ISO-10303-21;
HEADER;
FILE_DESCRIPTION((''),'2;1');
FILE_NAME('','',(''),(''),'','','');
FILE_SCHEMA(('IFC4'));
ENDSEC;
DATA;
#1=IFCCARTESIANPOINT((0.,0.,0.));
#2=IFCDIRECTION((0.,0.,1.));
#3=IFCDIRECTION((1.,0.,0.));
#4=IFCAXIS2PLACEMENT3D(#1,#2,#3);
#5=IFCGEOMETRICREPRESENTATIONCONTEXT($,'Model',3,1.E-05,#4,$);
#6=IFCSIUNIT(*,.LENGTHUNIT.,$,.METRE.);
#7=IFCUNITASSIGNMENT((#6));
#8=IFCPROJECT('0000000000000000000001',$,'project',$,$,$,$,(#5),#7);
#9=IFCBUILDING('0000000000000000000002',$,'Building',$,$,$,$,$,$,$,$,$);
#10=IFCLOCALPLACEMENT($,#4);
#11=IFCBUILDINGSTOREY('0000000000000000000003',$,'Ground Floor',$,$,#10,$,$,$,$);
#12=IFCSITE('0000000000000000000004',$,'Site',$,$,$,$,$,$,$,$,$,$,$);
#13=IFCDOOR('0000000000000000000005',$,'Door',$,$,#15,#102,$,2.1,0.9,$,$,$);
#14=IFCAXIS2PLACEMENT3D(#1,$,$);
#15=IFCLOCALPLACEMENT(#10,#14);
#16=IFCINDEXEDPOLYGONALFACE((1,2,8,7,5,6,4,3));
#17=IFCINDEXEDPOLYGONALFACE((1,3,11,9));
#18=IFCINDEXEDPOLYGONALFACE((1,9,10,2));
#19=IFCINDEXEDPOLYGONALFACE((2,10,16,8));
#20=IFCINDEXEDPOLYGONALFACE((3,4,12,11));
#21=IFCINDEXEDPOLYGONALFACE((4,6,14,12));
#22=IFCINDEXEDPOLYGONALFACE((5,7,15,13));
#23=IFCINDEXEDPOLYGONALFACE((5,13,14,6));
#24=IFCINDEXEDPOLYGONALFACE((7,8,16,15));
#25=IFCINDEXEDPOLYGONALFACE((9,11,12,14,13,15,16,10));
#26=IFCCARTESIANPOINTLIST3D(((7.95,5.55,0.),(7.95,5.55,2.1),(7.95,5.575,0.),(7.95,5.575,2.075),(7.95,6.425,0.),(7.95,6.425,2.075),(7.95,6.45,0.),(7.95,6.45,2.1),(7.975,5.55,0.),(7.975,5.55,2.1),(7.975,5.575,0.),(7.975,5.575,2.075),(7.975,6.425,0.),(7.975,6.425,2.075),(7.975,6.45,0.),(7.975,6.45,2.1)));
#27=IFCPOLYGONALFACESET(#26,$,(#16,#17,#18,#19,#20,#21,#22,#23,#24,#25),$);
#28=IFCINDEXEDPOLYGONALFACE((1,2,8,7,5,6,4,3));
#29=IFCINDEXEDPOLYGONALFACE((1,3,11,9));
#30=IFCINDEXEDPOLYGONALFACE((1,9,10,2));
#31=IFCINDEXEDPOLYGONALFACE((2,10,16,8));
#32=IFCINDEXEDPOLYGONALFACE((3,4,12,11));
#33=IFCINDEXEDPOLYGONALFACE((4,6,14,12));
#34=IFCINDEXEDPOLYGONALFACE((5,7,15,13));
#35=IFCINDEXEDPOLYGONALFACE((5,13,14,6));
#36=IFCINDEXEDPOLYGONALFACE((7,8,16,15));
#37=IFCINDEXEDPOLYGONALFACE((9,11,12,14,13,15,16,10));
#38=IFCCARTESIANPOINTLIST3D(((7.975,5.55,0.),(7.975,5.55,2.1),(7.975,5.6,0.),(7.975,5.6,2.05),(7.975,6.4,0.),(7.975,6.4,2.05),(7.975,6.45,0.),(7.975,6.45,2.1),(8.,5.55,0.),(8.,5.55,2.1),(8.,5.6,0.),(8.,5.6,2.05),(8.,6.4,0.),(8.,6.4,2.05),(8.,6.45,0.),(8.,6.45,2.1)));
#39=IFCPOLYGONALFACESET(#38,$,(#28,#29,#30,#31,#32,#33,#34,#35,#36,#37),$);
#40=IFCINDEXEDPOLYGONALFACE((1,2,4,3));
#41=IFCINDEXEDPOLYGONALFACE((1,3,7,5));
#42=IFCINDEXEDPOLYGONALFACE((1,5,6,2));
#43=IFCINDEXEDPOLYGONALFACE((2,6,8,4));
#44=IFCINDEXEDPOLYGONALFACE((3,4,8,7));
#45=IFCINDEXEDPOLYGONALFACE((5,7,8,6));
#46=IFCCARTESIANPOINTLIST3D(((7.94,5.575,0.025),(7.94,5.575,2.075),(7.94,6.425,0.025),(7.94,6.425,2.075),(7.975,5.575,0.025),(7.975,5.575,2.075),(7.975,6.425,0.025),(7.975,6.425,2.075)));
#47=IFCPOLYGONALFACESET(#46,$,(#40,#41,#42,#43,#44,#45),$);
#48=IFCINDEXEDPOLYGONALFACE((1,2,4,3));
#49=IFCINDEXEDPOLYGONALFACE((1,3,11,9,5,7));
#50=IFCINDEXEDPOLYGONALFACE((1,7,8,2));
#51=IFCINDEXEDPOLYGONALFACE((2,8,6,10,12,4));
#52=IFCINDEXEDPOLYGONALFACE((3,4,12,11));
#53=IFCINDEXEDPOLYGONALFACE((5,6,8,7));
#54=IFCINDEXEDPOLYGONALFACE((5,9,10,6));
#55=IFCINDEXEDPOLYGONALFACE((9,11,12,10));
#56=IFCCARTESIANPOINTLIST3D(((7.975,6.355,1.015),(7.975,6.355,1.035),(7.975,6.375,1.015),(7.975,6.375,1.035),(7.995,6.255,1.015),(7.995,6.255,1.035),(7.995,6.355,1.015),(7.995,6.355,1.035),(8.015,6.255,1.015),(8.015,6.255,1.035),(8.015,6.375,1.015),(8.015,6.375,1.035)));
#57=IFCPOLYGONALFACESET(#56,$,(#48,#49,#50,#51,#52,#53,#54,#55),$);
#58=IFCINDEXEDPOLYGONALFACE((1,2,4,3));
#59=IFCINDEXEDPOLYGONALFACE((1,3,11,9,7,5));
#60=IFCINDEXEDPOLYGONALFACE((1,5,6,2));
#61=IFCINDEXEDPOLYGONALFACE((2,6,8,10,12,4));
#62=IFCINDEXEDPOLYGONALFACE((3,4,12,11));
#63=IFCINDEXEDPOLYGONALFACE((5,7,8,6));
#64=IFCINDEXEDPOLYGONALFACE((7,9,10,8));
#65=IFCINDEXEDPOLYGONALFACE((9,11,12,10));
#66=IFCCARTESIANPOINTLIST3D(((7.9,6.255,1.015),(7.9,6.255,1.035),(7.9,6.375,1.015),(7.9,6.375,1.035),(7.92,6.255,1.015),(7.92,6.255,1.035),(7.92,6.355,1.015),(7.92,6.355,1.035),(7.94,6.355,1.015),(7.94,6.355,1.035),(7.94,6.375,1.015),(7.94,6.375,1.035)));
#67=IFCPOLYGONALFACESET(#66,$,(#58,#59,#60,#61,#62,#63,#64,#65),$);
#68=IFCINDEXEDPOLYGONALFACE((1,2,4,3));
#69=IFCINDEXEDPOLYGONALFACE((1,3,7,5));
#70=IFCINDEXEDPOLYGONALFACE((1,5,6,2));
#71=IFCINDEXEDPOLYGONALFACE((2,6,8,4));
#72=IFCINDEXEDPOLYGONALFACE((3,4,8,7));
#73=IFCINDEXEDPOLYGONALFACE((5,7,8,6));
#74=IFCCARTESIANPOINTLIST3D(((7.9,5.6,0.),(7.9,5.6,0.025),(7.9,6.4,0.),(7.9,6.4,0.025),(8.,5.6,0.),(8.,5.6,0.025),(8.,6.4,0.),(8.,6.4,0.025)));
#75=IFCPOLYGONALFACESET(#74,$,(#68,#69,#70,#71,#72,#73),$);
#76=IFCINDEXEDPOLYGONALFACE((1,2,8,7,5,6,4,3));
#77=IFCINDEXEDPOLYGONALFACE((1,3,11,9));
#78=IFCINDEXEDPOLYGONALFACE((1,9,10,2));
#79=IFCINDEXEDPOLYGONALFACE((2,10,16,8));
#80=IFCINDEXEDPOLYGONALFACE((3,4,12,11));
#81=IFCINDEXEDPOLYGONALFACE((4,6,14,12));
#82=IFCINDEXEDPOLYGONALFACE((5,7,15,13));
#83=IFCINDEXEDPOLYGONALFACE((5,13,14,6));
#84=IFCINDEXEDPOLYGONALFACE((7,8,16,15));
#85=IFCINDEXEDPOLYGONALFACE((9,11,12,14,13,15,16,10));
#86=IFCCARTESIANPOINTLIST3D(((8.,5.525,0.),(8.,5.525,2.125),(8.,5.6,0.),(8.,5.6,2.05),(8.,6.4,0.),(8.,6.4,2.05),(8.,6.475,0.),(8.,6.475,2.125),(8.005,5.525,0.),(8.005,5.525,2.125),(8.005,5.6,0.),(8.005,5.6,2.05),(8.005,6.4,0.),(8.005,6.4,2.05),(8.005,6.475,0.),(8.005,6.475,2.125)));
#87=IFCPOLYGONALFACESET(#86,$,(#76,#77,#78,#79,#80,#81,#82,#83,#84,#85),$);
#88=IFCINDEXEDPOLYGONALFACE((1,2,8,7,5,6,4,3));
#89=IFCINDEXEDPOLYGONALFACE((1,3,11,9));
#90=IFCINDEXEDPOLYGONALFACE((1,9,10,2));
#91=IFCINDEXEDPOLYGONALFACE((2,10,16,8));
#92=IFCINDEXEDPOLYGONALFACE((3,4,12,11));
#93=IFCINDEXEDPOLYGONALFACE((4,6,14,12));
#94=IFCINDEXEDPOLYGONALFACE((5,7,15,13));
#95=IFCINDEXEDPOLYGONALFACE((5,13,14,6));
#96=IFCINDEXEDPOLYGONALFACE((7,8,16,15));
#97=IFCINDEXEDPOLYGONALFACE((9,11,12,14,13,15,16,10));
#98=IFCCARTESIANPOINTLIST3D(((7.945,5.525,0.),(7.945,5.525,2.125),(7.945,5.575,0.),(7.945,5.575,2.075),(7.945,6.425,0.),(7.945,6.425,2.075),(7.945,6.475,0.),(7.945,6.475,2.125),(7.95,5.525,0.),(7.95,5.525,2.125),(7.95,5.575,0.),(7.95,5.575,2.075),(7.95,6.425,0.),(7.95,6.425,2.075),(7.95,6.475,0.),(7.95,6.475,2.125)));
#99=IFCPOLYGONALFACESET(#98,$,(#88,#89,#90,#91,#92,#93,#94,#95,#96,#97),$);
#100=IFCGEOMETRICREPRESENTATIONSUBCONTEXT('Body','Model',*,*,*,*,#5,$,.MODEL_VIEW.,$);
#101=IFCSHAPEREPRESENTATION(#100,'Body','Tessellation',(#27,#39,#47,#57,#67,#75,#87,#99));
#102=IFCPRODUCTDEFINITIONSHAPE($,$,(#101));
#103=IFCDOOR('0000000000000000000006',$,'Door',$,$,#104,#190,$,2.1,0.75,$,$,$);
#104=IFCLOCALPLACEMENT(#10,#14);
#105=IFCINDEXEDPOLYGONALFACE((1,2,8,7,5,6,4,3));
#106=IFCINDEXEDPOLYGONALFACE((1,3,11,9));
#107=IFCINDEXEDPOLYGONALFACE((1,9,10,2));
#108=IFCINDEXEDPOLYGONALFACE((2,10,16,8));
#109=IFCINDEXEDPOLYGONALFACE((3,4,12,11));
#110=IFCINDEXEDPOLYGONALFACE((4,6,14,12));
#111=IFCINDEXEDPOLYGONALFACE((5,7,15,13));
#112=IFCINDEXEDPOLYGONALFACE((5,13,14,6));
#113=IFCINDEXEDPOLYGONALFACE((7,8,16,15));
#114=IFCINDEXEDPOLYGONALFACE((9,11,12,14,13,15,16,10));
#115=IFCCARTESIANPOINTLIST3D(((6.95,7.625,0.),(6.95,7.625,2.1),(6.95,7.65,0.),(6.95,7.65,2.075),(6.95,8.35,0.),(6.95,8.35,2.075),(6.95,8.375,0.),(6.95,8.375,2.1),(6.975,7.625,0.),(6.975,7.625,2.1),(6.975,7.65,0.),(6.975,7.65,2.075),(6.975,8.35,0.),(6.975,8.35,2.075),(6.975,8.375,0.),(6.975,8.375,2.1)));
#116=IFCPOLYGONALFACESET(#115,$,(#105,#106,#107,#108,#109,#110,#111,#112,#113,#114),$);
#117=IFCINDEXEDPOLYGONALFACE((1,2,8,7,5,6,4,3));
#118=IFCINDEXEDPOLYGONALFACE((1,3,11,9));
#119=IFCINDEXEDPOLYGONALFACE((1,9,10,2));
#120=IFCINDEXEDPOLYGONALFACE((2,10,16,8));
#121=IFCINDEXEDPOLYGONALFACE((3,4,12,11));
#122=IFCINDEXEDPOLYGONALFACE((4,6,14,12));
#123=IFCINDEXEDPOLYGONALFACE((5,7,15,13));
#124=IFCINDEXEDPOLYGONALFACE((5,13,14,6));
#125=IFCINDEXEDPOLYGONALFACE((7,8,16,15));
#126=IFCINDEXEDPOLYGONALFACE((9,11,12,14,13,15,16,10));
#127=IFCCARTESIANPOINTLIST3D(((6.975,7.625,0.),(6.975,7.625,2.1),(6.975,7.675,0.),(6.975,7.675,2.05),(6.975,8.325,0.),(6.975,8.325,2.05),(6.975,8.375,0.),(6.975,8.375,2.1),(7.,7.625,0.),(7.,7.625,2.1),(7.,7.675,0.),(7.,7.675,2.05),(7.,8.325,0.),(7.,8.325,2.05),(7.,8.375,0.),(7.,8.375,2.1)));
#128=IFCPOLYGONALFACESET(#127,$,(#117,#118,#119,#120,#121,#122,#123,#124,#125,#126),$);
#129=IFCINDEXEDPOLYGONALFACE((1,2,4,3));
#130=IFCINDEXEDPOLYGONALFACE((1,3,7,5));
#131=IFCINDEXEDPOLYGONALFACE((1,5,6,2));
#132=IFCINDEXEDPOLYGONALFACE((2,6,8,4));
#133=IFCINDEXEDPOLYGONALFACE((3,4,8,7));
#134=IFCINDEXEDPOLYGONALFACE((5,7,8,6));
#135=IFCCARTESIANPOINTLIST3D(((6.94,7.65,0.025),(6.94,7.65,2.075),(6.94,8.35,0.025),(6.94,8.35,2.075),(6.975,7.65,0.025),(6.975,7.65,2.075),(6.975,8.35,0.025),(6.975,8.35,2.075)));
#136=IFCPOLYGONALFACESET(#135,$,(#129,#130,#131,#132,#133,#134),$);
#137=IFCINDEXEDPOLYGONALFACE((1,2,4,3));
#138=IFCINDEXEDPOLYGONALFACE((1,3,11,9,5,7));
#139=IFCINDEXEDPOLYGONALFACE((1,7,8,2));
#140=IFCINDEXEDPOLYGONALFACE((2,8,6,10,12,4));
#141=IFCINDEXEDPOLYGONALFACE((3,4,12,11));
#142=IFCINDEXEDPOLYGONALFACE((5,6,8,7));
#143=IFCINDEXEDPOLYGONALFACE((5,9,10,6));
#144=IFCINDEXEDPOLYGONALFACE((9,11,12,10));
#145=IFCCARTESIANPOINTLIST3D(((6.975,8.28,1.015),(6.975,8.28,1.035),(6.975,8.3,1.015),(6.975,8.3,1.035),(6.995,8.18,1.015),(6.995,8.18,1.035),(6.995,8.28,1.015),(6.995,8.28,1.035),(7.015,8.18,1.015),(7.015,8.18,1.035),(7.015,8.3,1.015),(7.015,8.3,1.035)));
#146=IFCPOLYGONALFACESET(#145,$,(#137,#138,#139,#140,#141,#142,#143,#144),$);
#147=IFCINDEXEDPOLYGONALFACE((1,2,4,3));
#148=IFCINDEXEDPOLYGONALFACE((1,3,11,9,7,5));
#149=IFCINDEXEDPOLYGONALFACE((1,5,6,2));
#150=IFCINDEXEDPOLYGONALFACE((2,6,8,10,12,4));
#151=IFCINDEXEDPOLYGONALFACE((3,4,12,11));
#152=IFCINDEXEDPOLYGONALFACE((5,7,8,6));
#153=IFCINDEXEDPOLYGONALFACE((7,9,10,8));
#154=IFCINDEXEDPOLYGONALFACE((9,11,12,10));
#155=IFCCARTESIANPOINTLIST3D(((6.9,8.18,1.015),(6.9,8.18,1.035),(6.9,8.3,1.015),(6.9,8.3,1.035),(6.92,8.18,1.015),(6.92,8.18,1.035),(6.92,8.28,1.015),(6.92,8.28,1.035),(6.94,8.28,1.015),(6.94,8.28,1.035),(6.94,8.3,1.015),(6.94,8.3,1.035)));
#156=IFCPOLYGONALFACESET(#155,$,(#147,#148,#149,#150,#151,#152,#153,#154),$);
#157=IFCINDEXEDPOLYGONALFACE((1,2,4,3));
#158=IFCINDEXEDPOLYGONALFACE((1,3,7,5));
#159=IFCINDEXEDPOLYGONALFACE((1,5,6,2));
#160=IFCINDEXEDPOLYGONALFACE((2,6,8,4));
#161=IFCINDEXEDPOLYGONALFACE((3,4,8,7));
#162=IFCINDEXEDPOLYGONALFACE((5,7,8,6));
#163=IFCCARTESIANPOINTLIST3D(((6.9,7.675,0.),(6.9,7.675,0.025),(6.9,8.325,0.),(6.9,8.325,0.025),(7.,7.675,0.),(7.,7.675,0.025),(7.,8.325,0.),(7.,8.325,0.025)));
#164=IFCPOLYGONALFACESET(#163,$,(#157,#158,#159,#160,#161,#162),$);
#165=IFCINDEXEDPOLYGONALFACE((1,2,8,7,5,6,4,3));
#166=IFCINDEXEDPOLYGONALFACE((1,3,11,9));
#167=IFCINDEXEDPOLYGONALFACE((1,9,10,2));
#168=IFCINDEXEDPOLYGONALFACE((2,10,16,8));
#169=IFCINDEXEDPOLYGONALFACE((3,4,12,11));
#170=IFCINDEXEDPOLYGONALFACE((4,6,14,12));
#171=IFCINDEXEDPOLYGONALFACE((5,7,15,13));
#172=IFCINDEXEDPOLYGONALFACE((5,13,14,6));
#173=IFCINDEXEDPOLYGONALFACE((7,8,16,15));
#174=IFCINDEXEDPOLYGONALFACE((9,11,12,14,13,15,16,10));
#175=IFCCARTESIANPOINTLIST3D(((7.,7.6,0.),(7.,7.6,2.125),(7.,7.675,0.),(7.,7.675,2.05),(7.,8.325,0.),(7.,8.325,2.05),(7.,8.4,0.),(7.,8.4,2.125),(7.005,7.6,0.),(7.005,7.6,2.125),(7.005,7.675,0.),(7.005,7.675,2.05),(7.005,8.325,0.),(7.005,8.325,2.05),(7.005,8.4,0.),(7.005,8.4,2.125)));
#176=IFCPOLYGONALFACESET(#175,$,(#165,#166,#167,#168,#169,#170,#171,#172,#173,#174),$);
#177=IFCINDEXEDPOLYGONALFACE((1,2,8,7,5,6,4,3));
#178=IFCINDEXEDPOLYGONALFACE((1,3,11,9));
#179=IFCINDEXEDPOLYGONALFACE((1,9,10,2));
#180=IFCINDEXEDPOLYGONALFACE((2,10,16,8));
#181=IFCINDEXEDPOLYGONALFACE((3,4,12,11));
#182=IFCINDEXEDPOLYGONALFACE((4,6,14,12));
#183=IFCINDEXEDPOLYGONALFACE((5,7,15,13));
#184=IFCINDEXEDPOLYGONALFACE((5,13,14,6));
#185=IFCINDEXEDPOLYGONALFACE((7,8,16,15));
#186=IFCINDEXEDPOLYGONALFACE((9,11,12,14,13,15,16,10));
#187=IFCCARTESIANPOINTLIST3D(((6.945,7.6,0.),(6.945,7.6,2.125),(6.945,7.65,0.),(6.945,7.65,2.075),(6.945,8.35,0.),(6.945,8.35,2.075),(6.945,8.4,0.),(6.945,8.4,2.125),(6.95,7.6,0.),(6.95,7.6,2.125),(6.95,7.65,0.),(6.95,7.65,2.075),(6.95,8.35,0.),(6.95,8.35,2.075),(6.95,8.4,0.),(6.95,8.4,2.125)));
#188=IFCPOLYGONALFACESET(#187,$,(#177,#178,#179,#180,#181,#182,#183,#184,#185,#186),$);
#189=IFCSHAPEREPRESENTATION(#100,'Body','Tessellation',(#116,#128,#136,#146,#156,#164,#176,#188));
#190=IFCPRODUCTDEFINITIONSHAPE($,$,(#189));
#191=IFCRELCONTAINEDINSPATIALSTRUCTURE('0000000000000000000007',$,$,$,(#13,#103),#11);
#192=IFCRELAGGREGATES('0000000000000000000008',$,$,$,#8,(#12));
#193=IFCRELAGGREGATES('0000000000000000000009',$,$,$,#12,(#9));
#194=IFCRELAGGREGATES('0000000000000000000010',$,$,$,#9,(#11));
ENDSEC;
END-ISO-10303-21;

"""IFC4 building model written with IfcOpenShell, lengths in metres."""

from ifc_helpers import new_model, si_unit, frame, origin_with_axes, place, context, subcontext, project, spatial, line, indexed_curve, outline, extrude, element, save


model = new_model("IFC4")

# Units and contexts
model_context = context("Model", 3, precision=1e-05, world=origin_with_axes())
body_context = subcontext(model_context, "Body", "Model", "MODEL_VIEW")
ifc_project = project(units=[si_unit("LENGTHUNIT", "METRE")], contexts=[model_context])

# Site, building, storey
site = spatial("IfcSite", under=ifc_project, Name="Site")
building = spatial("IfcBuilding", under=site, Name="Building")
storey_placement = place(None, origin_with_axes())
storey = spatial("IfcBuildingStorey", under=building, at=storey_placement, Name="Ground Floor")

# Doors
door_1_placement = place(storey_placement, frame((8.0, 5.55, 0.0), z_axis=(0.0, 0.0, 1.0), x_axis=(0.0, 1.0, 0.0)))
element("IfcDoor", 1, at=door_1_placement, inside=storey, Name="Door", OverallHeight=2.1, OverallWidth=0.9, context=body_context, shape_type="SweptSolid", body=[
    extrude(outline(indexed_curve([(0.0, 0.0), (0.0, 2.1), (0.9, 2.1), (0.9, 0.0), (0.875, 0.0), (0.875, 2.075), (0.025, 2.075), (0.025, 0.0)], segments=[line(1, 2, 3, 4, 5, 6, 7, 8, 1)])), frame((0.0, 0.025, 0.0), z_axis=(0.0, -1.0, 0.0), x_axis=(1.0, 0.0, 0.0)), (0.0, 0.0, -1.0), 0.025),
    extrude(outline(indexed_curve([(0.0, 0.0), (0.0, 2.1), (0.9, 2.1), (0.9, 0.0), (0.85, 0.0), (0.85, 2.05), (0.05, 2.05), (0.05, 0.0)], segments=[line(1, 2, 3, 4, 5, 6, 7, 8, 1)])), frame((0.0, 0.0, 0.0), z_axis=(0.0, -1.0, 0.0), x_axis=(1.0, 0.0, 0.0)), (0.0, 0.0, -1.0), 0.025),
    extrude(outline(indexed_curve([(0.0, 0.0), (0.85, 0.0), (0.85, 0.035), (0.0, 0.035)], segments=[line(1, 2, 3, 4, 1)])), frame((0.025, 0.025, 0.025), z_axis=(0.0, 0.0, 1.0), x_axis=(1.0, 0.0, 0.0)), (0.0, 0.0, 1.0), 2.05),
    extrude(outline(indexed_curve([(0.0, 0.0), (0.0, -0.04), (-0.12, -0.04), (-0.12, -0.02), (-0.02, -0.02), (-0.02, 0.0)], segments=[line(1, 2, 3, 4, 5, 6, 1)])), frame((0.825, 0.025, 1.015), z_axis=(0.0, 0.0, 1.0), x_axis=(1.0, 0.0, 0.0)), (0.0, 0.0, 1.0), 0.02),
    extrude(outline(indexed_curve([(0.0, 0.0), (0.0, 0.04), (-0.12, 0.04), (-0.12, 0.02), (-0.02, 0.02), (-0.02, 0.0)], segments=[line(1, 2, 3, 4, 5, 6, 1)])), frame((0.825, 0.06, 1.015), z_axis=(0.0, 0.0, 1.0), x_axis=(1.0, 0.0, 0.0)), (0.0, 0.0, 1.0), 0.02),
    extrude(outline(indexed_curve([(0.0, 0.0), (0.8, 0.0), (0.8, 0.1), (0.0, 0.1)], segments=[line(1, 2, 3, 4, 1)])), frame((0.05, 0.0, 0.0), z_axis=(0.0, 0.0, 1.0), x_axis=(1.0, 0.0, 0.0)), (0.0, 0.0, 1.0), 0.025),
    extrude(outline(indexed_curve([(0.0, 0.0), (0.0, 2.125), (0.95, 2.125), (0.95, 0.0), (0.875, 0.0), (0.875, 2.05), (0.075, 2.05), (0.075, 0.0)], segments=[line(1, 2, 3, 4, 5, 6, 7, 8, 1)])), frame((-0.025, -0.005, 0.0), z_axis=(0.0, -1.0, 0.0), x_axis=(1.0, 0.0, 0.0)), (0.0, 0.0, -1.0), 0.005),
    extrude(outline(indexed_curve([(0.0, 0.0), (0.0, 2.125), (0.95, 2.125), (0.95, 0.0), (0.9, 0.0), (0.9, 2.075), (0.05, 2.075), (0.05, 0.0)], segments=[line(1, 2, 3, 4, 5, 6, 7, 8, 1)])), frame((-0.025, 0.05, 0.0), z_axis=(0.0, -1.0, 0.0), x_axis=(1.0, 0.0, 0.0)), (0.0, 0.0, -1.0), 0.005),
])
door_2_placement = place(storey_placement, frame((7.0, 7.625, 0.0), z_axis=(0.0, 0.0, 1.0), x_axis=(0.0, 1.0, 0.0)))
element("IfcDoor", 2, at=door_2_placement, inside=storey, Name="Door", OverallHeight=2.1, OverallWidth=0.75, context=body_context, shape_type="SweptSolid", body=[
    extrude(outline(indexed_curve([(0.0, 0.0), (0.0, 2.1), (0.75, 2.1), (0.75, 0.0), (0.725, 0.0), (0.725, 2.075), (0.025, 2.075), (0.025, 0.0)], segments=[line(1, 2, 3, 4, 5, 6, 7, 8, 1)])), frame((0.0, 0.025, 0.0), z_axis=(0.0, -1.0, 0.0), x_axis=(1.0, 0.0, 0.0)), (0.0, 0.0, -1.0), 0.025),
    extrude(outline(indexed_curve([(0.0, 0.0), (0.0, 2.1), (0.75, 2.1), (0.75, 0.0), (0.7, 0.0), (0.7, 2.05), (0.05, 2.05), (0.05, 0.0)], segments=[line(1, 2, 3, 4, 5, 6, 7, 8, 1)])), frame((0.0, 0.0, 0.0), z_axis=(0.0, -1.0, 0.0), x_axis=(1.0, 0.0, 0.0)), (0.0, 0.0, -1.0), 0.025),
    extrude(outline(indexed_curve([(0.0, 0.0), (0.7, 0.0), (0.7, 0.035), (0.0, 0.035)], segments=[line(1, 2, 3, 4, 1)])), frame((0.025, 0.025, 0.025), z_axis=(0.0, 0.0, 1.0), x_axis=(1.0, 0.0, 0.0)), (0.0, 0.0, 1.0), 2.05),
    extrude(outline(indexed_curve([(0.0, 0.0), (0.0, -0.04), (-0.12, -0.04), (-0.12, -0.02), (-0.02, -0.02), (-0.02, 0.0)], segments=[line(1, 2, 3, 4, 5, 6, 1)])), frame((0.675, 0.025, 1.015), z_axis=(0.0, 0.0, 1.0), x_axis=(1.0, 0.0, 0.0)), (0.0, 0.0, 1.0), 0.02),
    extrude(outline(indexed_curve([(0.0, 0.0), (0.0, 0.04), (-0.12, 0.04), (-0.12, 0.02), (-0.02, 0.02), (-0.02, 0.0)], segments=[line(1, 2, 3, 4, 5, 6, 1)])), frame((0.675, 0.06, 1.015), z_axis=(0.0, 0.0, 1.0), x_axis=(1.0, 0.0, 0.0)), (0.0, 0.0, 1.0), 0.02),
    extrude(outline(indexed_curve([(0.0, 0.0), (0.65, 0.0), (0.65, 0.1), (0.0, 0.1)], segments=[line(1, 2, 3, 4, 1)])), frame((0.05, 0.0, 0.0), z_axis=(0.0, 0.0, 1.0), x_axis=(1.0, 0.0, 0.0)), (0.0, 0.0, 1.0), 0.025),
    extrude(outline(indexed_curve([(0.0, 0.0), (0.0, 2.125), (0.8, 2.125), (0.8, 0.0), (0.725, 0.0), (0.725, 2.05), (0.075, 2.05), (0.075, 0.0)], segments=[line(1, 2, 3, 4, 5, 6, 7, 8, 1)])), frame((-0.025, -0.005, 0.0), z_axis=(0.0, -1.0, 0.0), x_axis=(1.0, 0.0, 0.0)), (0.0, 0.0, -1.0), 0.005),
    extrude(outline(indexed_curve([(0.0, 0.0), (0.0, 2.125), (0.8, 2.125), (0.8, 0.0), (0.75, 0.0), (0.75, 2.075), (0.05, 2.075), (0.05, 0.0)], segments=[line(1, 2, 3, 4, 5, 6, 7, 8, 1)])), frame((-0.025, 0.05, 0.0), z_axis=(0.0, -1.0, 0.0), x_axis=(1.0, 0.0, 0.0)), (0.0, 0.0, -1.0), 0.005),
])

save(model, "model.ifc")
